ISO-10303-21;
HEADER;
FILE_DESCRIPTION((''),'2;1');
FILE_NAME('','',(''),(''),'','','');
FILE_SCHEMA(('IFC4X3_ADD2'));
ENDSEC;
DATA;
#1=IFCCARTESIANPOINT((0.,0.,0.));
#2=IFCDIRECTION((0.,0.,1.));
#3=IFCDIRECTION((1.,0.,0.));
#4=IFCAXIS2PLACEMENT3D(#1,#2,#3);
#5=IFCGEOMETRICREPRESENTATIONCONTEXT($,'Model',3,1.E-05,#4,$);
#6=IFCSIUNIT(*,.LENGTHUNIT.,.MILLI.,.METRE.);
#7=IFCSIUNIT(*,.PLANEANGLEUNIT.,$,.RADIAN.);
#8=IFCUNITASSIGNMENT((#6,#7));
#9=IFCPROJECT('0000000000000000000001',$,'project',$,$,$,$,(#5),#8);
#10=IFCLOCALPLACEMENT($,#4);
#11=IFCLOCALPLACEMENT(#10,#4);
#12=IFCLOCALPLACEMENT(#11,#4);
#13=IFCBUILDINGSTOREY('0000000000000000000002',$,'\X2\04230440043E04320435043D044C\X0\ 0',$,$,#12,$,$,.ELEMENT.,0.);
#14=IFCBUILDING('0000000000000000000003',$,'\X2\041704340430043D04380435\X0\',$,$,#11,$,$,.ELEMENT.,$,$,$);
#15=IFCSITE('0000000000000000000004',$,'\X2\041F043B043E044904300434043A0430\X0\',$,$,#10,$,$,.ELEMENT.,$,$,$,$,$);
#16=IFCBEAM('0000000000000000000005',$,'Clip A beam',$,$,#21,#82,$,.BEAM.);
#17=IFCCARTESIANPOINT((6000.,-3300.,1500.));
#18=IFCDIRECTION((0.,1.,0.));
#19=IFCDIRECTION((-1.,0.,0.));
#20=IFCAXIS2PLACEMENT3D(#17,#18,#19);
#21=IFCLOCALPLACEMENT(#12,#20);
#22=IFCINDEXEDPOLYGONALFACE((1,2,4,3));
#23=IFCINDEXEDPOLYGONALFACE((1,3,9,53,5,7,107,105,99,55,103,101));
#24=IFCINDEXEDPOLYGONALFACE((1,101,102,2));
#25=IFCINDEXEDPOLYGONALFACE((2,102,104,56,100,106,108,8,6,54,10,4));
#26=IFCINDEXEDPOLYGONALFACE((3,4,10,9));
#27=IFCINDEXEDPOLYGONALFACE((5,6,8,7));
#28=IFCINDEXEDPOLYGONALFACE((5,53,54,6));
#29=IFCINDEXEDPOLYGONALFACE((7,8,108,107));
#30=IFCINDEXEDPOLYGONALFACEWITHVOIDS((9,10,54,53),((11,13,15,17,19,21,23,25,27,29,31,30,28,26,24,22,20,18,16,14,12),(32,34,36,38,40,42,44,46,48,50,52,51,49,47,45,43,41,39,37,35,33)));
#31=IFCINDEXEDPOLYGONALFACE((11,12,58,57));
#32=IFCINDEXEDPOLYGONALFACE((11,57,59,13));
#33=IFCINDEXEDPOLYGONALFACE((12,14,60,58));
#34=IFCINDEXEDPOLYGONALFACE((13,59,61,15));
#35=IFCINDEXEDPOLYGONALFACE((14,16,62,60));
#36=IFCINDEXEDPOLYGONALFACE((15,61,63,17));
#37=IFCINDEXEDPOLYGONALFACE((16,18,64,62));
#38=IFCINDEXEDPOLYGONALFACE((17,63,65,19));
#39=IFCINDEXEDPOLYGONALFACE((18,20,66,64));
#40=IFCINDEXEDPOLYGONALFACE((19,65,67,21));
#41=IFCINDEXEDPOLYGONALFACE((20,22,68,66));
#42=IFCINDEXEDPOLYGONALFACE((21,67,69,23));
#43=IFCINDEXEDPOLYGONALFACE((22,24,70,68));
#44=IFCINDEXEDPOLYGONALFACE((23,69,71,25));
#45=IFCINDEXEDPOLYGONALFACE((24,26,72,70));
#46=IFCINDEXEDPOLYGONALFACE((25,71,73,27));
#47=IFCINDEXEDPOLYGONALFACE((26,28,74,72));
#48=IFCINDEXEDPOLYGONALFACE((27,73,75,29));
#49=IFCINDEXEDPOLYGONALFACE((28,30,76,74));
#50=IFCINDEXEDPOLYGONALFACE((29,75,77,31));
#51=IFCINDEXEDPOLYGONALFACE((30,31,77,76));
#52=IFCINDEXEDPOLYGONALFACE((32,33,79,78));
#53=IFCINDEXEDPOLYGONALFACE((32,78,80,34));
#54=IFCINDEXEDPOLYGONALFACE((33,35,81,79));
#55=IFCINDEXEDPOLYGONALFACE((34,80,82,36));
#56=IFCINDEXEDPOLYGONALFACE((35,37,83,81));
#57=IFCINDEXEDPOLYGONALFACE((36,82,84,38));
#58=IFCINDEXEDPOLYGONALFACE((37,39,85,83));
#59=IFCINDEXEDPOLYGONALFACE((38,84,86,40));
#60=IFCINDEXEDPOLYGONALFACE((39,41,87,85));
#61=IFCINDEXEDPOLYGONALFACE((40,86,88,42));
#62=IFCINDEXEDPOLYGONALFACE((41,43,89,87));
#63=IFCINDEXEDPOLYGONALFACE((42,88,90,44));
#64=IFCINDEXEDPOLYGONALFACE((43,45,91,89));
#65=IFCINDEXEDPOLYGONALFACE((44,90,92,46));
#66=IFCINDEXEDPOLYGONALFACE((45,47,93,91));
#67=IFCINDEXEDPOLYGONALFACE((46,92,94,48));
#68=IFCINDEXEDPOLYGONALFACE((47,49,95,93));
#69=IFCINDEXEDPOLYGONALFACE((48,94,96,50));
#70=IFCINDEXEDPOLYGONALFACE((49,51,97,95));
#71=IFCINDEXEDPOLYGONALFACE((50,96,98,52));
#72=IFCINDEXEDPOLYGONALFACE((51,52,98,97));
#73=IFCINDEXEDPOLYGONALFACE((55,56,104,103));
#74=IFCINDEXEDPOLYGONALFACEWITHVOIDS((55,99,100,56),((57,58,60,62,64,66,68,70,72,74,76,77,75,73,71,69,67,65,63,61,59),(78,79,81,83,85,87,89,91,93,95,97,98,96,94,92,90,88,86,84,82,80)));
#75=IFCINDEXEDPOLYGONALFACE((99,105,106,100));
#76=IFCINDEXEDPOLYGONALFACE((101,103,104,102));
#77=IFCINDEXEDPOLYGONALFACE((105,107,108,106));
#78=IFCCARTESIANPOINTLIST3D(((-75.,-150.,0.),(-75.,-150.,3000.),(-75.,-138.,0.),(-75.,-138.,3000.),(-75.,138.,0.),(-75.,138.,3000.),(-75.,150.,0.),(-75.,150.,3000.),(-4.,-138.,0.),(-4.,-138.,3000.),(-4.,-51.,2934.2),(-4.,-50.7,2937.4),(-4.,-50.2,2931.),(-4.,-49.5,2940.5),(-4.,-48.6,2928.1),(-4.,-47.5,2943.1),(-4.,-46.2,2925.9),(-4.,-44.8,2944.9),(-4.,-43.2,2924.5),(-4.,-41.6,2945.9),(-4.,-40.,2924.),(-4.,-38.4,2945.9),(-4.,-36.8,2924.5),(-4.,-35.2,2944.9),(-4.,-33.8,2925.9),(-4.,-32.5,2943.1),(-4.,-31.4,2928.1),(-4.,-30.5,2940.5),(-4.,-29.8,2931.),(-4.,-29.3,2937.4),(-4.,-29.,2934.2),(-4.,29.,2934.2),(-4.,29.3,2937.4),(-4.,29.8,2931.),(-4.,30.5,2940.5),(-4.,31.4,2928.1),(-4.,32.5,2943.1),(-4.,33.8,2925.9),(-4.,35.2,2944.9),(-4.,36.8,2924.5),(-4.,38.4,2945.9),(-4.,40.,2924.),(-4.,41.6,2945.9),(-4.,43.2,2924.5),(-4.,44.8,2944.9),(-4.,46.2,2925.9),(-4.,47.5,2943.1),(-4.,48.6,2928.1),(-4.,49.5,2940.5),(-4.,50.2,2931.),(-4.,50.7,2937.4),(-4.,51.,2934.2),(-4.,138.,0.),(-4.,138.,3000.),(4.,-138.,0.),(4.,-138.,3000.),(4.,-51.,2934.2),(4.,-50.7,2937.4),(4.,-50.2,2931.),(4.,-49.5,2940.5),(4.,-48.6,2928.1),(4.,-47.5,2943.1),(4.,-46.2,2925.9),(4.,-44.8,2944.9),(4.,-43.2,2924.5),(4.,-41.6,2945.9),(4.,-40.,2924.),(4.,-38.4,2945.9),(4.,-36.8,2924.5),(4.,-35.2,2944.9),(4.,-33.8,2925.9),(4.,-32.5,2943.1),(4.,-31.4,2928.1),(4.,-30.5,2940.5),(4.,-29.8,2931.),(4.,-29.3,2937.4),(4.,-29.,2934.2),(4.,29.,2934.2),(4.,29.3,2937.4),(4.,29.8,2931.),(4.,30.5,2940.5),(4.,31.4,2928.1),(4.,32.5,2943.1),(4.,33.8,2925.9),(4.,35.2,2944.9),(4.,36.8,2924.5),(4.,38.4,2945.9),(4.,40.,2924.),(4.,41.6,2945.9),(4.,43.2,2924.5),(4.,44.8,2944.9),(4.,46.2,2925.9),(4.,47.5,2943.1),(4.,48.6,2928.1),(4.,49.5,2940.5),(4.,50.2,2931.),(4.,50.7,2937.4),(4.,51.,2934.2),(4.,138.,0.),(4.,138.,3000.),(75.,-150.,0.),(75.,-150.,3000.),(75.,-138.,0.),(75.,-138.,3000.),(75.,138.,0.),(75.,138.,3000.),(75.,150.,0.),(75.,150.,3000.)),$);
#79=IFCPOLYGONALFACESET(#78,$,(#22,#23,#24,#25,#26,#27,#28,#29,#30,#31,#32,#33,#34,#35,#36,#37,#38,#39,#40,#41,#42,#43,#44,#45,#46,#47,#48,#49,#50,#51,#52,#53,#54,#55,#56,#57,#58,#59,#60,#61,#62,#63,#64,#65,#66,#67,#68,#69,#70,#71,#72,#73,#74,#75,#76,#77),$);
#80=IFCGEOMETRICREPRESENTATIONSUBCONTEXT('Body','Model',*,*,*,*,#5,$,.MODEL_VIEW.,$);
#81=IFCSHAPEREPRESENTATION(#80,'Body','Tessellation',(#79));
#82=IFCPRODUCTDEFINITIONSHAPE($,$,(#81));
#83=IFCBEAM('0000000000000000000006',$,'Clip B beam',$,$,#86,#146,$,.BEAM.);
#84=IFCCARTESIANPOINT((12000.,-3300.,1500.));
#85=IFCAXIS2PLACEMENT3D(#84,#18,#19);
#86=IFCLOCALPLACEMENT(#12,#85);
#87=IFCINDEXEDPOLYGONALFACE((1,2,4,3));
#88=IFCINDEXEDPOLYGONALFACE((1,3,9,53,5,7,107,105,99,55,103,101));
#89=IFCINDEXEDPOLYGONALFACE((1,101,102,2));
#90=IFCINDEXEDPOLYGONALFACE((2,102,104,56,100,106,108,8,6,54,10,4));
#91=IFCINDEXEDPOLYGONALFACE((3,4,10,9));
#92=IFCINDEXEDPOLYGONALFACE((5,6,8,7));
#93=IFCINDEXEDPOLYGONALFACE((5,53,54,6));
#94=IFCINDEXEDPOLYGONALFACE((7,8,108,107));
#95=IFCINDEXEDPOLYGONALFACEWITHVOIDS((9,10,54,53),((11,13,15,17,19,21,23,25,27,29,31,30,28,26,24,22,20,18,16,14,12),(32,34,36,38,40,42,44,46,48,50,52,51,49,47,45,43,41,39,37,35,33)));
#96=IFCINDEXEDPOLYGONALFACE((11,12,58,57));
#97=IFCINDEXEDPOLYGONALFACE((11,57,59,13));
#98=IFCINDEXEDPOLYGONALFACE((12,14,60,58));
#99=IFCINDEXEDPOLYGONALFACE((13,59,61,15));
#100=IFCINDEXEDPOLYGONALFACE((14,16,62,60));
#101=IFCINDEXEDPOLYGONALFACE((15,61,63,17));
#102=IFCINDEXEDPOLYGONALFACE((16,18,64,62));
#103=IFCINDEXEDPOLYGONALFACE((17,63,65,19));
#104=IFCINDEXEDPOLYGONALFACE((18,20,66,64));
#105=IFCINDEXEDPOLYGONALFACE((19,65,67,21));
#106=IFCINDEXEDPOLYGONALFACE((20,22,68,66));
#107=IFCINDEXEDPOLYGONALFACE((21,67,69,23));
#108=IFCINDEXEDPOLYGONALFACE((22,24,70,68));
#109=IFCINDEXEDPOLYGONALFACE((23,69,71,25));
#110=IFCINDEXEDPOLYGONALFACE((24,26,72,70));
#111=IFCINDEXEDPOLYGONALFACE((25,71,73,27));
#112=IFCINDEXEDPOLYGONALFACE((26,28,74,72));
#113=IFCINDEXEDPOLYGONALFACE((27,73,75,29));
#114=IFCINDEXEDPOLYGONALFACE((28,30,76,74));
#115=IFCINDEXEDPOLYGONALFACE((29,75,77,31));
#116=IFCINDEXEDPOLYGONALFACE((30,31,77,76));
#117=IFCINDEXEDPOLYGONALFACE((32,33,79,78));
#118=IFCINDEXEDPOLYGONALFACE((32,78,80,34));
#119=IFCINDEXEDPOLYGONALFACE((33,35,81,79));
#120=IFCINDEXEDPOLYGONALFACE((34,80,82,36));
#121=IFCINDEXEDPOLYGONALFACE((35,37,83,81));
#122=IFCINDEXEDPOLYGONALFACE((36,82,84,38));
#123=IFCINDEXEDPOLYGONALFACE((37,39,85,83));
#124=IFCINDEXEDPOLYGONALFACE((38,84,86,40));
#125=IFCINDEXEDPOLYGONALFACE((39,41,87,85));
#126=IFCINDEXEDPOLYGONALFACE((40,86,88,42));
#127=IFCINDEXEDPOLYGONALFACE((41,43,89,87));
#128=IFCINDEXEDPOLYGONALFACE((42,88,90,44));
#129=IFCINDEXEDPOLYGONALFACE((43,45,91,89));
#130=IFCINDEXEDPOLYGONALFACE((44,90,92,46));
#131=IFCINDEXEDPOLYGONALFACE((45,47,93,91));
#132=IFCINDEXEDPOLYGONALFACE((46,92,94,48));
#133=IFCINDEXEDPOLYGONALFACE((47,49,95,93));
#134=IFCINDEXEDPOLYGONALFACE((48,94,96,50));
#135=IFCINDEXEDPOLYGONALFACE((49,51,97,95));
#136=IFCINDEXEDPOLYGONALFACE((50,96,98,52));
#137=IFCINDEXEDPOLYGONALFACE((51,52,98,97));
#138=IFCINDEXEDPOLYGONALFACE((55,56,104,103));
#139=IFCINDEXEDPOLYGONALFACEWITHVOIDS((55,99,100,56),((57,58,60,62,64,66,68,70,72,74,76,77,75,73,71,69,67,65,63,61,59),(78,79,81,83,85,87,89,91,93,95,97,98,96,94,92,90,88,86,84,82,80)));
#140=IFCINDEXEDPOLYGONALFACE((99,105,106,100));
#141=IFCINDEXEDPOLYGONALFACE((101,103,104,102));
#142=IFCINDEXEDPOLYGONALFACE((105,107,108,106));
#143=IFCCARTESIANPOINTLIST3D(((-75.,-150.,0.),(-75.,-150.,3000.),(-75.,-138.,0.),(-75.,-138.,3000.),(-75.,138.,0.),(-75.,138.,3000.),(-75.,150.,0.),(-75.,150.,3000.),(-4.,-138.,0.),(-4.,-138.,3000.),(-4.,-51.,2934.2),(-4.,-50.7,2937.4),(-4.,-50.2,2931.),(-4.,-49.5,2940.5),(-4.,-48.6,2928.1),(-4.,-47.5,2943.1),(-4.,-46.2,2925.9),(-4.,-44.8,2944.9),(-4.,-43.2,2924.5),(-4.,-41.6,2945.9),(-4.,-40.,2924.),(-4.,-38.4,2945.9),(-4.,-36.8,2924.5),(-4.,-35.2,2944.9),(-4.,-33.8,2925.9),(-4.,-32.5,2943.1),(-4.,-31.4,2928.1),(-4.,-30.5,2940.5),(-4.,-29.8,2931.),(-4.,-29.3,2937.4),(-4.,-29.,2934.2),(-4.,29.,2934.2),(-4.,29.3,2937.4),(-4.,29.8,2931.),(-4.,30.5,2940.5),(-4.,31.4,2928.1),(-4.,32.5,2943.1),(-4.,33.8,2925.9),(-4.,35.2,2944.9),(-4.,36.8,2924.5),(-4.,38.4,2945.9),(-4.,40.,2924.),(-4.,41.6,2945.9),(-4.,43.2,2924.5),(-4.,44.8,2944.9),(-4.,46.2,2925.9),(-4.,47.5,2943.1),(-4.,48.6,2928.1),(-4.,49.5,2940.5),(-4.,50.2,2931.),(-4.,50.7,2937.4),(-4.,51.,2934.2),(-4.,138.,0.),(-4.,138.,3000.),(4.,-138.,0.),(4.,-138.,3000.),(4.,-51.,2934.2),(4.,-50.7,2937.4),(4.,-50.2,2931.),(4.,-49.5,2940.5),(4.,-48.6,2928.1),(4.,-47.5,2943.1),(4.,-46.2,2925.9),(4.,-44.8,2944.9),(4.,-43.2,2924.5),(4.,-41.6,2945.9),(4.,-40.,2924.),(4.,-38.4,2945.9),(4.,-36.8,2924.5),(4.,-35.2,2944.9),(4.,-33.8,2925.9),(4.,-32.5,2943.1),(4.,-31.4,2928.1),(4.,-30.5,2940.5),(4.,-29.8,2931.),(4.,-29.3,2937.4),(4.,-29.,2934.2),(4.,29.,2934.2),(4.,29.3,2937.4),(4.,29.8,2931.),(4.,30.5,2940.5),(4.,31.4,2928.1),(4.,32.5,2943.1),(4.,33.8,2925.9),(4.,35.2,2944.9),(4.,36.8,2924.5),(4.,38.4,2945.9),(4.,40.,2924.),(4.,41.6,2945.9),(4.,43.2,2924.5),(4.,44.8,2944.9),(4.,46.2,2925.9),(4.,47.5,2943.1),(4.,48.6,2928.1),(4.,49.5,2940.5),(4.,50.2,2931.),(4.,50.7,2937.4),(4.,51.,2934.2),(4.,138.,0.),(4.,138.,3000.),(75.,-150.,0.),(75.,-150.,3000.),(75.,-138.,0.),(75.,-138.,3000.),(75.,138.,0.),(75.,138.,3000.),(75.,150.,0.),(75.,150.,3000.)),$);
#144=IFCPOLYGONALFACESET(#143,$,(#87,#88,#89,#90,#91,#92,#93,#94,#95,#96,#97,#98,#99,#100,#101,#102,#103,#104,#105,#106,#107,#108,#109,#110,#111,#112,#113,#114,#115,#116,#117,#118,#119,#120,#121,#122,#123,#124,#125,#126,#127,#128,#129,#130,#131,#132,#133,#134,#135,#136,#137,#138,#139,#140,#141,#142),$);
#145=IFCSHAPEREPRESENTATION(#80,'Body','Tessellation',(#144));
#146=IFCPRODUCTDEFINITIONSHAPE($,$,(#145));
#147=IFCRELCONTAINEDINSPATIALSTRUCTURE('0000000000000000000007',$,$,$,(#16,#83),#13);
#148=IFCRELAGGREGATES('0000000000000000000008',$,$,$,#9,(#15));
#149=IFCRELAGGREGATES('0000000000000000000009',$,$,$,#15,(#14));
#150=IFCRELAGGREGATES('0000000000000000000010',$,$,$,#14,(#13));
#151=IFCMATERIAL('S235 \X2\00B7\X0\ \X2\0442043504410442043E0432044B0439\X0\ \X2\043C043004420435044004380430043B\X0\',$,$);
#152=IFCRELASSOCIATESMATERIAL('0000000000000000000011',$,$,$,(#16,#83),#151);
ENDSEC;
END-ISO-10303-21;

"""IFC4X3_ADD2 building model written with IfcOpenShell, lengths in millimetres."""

from ifc_helpers import new_model, si_unit, frame, origin_with_axes, place, context, subcontext, project, spatial, circle, i_section, extrude, material, element, save


model = new_model("IFC4X3_ADD2")

# Units and contexts
model_context = context("Model", 3, precision=1e-05, world=origin_with_axes())
body_context = subcontext(model_context, "Body", "Model", "MODEL_VIEW")
ifc_project = project(units=[si_unit("LENGTHUNIT", "METRE", prefix="MILLI"), si_unit("PLANEANGLEUNIT", "RADIAN")], contexts=[model_context])

# Site, building, storey
site_placement = place(None, origin_with_axes())
site = spatial("IfcSite", under=ifc_project, at=site_placement, Name="Площадка", CompositionType="ELEMENT")
building_placement = place(site_placement, origin_with_axes())
building = spatial("IfcBuilding", under=site, at=building_placement, Name="Здание", CompositionType="ELEMENT")
storey_placement = place(building_placement, origin_with_axes())
storey = spatial("IfcBuildingStorey", under=building, at=storey_placement, Name="Уровень 0", CompositionType="ELEMENT", Elevation=0.0)

# Shared definitions
ifc_material = material(Name="S235 · тестовый материал")

# Beam, openings
beam_1_placement = place(storey_placement, frame((6000.0, -3300.0, 1500.0), z_axis=(0.0, 1.0, 0.0), x_axis=(-1.0, 0.0, 0.0)))
beam_1 = element("IfcBeam", 1, at=beam_1_placement, inside=storey, material=ifc_material, Name="Clip A beam", PredefinedType="BEAM", context=body_context, shape_type="SweptSolid", body=[
    extrude(i_section(OverallWidth=150.0, OverallDepth=300.0, WebThickness=8.0, FlangeThickness=12.0), origin_with_axes(), (0.0, 0.0, 1.0), 3000.0),
])
opening_1_placement = place(beam_1_placement, frame((25.0, 40.0, 2935.0), z_axis=(-1.0, 0.0, 0.0), x_axis=(0.0, 0.0, -1.0)))
element("IfcOpeningElement", 2, at=opening_1_placement, cuts=beam_1, PredefinedType="OPENING", context=body_context, shape_type="SweptSolid", body=[
    extrude(circle(Radius=11.0), origin_with_axes(), (0.0, 0.0, 1.0), 30.0),
])
opening_2_placement = place(beam_1_placement, frame((25.0, -40.0, 2935.0), z_axis=(-1.0, 0.0, 0.0), x_axis=(0.0, 0.0, -1.0)))
element("IfcOpeningElement", 3, at=opening_2_placement, cuts=beam_1, PredefinedType="OPENING", context=body_context, shape_type="SweptSolid", body=[
    extrude(circle(Radius=11.0), origin_with_axes(), (0.0, 0.0, 1.0), 30.0),
])

# Beam, openings
beam_2_placement = place(storey_placement, frame((12000.0, -3300.0, 1500.0), z_axis=(0.0, 1.0, 0.0), x_axis=(-1.0, 0.0, 0.0)))
beam_2 = element("IfcBeam", 4, at=beam_2_placement, inside=storey, material=ifc_material, Name="Clip B beam", PredefinedType="BEAM", context=body_context, shape_type="SweptSolid", body=[
    extrude(i_section(OverallWidth=150.0, OverallDepth=300.0, WebThickness=8.0, FlangeThickness=12.0), origin_with_axes(), (0.0, 0.0, 1.0), 3000.0),
])
opening_3_placement = place(beam_2_placement, frame((25.0, 40.0, 2935.0), z_axis=(-1.0, 0.0, 0.0), x_axis=(0.0, 0.0, -1.0)))
element("IfcOpeningElement", 5, at=opening_3_placement, cuts=beam_2, PredefinedType="OPENING", context=body_context, shape_type="SweptSolid", body=[
    extrude(circle(Radius=11.0), origin_with_axes(), (0.0, 0.0, 1.0), 30.0),
])
opening_4_placement = place(beam_2_placement, frame((25.0, -40.0, 2935.0), z_axis=(-1.0, 0.0, 0.0), x_axis=(0.0, 0.0, -1.0)))
element("IfcOpeningElement", 6, at=opening_4_placement, cuts=beam_2, PredefinedType="OPENING", context=body_context, shape_type="SweptSolid", body=[
    extrude(circle(Radius=11.0), origin_with_axes(), (0.0, 0.0, 1.0), 30.0),
])

save(model, "model.ifc")
